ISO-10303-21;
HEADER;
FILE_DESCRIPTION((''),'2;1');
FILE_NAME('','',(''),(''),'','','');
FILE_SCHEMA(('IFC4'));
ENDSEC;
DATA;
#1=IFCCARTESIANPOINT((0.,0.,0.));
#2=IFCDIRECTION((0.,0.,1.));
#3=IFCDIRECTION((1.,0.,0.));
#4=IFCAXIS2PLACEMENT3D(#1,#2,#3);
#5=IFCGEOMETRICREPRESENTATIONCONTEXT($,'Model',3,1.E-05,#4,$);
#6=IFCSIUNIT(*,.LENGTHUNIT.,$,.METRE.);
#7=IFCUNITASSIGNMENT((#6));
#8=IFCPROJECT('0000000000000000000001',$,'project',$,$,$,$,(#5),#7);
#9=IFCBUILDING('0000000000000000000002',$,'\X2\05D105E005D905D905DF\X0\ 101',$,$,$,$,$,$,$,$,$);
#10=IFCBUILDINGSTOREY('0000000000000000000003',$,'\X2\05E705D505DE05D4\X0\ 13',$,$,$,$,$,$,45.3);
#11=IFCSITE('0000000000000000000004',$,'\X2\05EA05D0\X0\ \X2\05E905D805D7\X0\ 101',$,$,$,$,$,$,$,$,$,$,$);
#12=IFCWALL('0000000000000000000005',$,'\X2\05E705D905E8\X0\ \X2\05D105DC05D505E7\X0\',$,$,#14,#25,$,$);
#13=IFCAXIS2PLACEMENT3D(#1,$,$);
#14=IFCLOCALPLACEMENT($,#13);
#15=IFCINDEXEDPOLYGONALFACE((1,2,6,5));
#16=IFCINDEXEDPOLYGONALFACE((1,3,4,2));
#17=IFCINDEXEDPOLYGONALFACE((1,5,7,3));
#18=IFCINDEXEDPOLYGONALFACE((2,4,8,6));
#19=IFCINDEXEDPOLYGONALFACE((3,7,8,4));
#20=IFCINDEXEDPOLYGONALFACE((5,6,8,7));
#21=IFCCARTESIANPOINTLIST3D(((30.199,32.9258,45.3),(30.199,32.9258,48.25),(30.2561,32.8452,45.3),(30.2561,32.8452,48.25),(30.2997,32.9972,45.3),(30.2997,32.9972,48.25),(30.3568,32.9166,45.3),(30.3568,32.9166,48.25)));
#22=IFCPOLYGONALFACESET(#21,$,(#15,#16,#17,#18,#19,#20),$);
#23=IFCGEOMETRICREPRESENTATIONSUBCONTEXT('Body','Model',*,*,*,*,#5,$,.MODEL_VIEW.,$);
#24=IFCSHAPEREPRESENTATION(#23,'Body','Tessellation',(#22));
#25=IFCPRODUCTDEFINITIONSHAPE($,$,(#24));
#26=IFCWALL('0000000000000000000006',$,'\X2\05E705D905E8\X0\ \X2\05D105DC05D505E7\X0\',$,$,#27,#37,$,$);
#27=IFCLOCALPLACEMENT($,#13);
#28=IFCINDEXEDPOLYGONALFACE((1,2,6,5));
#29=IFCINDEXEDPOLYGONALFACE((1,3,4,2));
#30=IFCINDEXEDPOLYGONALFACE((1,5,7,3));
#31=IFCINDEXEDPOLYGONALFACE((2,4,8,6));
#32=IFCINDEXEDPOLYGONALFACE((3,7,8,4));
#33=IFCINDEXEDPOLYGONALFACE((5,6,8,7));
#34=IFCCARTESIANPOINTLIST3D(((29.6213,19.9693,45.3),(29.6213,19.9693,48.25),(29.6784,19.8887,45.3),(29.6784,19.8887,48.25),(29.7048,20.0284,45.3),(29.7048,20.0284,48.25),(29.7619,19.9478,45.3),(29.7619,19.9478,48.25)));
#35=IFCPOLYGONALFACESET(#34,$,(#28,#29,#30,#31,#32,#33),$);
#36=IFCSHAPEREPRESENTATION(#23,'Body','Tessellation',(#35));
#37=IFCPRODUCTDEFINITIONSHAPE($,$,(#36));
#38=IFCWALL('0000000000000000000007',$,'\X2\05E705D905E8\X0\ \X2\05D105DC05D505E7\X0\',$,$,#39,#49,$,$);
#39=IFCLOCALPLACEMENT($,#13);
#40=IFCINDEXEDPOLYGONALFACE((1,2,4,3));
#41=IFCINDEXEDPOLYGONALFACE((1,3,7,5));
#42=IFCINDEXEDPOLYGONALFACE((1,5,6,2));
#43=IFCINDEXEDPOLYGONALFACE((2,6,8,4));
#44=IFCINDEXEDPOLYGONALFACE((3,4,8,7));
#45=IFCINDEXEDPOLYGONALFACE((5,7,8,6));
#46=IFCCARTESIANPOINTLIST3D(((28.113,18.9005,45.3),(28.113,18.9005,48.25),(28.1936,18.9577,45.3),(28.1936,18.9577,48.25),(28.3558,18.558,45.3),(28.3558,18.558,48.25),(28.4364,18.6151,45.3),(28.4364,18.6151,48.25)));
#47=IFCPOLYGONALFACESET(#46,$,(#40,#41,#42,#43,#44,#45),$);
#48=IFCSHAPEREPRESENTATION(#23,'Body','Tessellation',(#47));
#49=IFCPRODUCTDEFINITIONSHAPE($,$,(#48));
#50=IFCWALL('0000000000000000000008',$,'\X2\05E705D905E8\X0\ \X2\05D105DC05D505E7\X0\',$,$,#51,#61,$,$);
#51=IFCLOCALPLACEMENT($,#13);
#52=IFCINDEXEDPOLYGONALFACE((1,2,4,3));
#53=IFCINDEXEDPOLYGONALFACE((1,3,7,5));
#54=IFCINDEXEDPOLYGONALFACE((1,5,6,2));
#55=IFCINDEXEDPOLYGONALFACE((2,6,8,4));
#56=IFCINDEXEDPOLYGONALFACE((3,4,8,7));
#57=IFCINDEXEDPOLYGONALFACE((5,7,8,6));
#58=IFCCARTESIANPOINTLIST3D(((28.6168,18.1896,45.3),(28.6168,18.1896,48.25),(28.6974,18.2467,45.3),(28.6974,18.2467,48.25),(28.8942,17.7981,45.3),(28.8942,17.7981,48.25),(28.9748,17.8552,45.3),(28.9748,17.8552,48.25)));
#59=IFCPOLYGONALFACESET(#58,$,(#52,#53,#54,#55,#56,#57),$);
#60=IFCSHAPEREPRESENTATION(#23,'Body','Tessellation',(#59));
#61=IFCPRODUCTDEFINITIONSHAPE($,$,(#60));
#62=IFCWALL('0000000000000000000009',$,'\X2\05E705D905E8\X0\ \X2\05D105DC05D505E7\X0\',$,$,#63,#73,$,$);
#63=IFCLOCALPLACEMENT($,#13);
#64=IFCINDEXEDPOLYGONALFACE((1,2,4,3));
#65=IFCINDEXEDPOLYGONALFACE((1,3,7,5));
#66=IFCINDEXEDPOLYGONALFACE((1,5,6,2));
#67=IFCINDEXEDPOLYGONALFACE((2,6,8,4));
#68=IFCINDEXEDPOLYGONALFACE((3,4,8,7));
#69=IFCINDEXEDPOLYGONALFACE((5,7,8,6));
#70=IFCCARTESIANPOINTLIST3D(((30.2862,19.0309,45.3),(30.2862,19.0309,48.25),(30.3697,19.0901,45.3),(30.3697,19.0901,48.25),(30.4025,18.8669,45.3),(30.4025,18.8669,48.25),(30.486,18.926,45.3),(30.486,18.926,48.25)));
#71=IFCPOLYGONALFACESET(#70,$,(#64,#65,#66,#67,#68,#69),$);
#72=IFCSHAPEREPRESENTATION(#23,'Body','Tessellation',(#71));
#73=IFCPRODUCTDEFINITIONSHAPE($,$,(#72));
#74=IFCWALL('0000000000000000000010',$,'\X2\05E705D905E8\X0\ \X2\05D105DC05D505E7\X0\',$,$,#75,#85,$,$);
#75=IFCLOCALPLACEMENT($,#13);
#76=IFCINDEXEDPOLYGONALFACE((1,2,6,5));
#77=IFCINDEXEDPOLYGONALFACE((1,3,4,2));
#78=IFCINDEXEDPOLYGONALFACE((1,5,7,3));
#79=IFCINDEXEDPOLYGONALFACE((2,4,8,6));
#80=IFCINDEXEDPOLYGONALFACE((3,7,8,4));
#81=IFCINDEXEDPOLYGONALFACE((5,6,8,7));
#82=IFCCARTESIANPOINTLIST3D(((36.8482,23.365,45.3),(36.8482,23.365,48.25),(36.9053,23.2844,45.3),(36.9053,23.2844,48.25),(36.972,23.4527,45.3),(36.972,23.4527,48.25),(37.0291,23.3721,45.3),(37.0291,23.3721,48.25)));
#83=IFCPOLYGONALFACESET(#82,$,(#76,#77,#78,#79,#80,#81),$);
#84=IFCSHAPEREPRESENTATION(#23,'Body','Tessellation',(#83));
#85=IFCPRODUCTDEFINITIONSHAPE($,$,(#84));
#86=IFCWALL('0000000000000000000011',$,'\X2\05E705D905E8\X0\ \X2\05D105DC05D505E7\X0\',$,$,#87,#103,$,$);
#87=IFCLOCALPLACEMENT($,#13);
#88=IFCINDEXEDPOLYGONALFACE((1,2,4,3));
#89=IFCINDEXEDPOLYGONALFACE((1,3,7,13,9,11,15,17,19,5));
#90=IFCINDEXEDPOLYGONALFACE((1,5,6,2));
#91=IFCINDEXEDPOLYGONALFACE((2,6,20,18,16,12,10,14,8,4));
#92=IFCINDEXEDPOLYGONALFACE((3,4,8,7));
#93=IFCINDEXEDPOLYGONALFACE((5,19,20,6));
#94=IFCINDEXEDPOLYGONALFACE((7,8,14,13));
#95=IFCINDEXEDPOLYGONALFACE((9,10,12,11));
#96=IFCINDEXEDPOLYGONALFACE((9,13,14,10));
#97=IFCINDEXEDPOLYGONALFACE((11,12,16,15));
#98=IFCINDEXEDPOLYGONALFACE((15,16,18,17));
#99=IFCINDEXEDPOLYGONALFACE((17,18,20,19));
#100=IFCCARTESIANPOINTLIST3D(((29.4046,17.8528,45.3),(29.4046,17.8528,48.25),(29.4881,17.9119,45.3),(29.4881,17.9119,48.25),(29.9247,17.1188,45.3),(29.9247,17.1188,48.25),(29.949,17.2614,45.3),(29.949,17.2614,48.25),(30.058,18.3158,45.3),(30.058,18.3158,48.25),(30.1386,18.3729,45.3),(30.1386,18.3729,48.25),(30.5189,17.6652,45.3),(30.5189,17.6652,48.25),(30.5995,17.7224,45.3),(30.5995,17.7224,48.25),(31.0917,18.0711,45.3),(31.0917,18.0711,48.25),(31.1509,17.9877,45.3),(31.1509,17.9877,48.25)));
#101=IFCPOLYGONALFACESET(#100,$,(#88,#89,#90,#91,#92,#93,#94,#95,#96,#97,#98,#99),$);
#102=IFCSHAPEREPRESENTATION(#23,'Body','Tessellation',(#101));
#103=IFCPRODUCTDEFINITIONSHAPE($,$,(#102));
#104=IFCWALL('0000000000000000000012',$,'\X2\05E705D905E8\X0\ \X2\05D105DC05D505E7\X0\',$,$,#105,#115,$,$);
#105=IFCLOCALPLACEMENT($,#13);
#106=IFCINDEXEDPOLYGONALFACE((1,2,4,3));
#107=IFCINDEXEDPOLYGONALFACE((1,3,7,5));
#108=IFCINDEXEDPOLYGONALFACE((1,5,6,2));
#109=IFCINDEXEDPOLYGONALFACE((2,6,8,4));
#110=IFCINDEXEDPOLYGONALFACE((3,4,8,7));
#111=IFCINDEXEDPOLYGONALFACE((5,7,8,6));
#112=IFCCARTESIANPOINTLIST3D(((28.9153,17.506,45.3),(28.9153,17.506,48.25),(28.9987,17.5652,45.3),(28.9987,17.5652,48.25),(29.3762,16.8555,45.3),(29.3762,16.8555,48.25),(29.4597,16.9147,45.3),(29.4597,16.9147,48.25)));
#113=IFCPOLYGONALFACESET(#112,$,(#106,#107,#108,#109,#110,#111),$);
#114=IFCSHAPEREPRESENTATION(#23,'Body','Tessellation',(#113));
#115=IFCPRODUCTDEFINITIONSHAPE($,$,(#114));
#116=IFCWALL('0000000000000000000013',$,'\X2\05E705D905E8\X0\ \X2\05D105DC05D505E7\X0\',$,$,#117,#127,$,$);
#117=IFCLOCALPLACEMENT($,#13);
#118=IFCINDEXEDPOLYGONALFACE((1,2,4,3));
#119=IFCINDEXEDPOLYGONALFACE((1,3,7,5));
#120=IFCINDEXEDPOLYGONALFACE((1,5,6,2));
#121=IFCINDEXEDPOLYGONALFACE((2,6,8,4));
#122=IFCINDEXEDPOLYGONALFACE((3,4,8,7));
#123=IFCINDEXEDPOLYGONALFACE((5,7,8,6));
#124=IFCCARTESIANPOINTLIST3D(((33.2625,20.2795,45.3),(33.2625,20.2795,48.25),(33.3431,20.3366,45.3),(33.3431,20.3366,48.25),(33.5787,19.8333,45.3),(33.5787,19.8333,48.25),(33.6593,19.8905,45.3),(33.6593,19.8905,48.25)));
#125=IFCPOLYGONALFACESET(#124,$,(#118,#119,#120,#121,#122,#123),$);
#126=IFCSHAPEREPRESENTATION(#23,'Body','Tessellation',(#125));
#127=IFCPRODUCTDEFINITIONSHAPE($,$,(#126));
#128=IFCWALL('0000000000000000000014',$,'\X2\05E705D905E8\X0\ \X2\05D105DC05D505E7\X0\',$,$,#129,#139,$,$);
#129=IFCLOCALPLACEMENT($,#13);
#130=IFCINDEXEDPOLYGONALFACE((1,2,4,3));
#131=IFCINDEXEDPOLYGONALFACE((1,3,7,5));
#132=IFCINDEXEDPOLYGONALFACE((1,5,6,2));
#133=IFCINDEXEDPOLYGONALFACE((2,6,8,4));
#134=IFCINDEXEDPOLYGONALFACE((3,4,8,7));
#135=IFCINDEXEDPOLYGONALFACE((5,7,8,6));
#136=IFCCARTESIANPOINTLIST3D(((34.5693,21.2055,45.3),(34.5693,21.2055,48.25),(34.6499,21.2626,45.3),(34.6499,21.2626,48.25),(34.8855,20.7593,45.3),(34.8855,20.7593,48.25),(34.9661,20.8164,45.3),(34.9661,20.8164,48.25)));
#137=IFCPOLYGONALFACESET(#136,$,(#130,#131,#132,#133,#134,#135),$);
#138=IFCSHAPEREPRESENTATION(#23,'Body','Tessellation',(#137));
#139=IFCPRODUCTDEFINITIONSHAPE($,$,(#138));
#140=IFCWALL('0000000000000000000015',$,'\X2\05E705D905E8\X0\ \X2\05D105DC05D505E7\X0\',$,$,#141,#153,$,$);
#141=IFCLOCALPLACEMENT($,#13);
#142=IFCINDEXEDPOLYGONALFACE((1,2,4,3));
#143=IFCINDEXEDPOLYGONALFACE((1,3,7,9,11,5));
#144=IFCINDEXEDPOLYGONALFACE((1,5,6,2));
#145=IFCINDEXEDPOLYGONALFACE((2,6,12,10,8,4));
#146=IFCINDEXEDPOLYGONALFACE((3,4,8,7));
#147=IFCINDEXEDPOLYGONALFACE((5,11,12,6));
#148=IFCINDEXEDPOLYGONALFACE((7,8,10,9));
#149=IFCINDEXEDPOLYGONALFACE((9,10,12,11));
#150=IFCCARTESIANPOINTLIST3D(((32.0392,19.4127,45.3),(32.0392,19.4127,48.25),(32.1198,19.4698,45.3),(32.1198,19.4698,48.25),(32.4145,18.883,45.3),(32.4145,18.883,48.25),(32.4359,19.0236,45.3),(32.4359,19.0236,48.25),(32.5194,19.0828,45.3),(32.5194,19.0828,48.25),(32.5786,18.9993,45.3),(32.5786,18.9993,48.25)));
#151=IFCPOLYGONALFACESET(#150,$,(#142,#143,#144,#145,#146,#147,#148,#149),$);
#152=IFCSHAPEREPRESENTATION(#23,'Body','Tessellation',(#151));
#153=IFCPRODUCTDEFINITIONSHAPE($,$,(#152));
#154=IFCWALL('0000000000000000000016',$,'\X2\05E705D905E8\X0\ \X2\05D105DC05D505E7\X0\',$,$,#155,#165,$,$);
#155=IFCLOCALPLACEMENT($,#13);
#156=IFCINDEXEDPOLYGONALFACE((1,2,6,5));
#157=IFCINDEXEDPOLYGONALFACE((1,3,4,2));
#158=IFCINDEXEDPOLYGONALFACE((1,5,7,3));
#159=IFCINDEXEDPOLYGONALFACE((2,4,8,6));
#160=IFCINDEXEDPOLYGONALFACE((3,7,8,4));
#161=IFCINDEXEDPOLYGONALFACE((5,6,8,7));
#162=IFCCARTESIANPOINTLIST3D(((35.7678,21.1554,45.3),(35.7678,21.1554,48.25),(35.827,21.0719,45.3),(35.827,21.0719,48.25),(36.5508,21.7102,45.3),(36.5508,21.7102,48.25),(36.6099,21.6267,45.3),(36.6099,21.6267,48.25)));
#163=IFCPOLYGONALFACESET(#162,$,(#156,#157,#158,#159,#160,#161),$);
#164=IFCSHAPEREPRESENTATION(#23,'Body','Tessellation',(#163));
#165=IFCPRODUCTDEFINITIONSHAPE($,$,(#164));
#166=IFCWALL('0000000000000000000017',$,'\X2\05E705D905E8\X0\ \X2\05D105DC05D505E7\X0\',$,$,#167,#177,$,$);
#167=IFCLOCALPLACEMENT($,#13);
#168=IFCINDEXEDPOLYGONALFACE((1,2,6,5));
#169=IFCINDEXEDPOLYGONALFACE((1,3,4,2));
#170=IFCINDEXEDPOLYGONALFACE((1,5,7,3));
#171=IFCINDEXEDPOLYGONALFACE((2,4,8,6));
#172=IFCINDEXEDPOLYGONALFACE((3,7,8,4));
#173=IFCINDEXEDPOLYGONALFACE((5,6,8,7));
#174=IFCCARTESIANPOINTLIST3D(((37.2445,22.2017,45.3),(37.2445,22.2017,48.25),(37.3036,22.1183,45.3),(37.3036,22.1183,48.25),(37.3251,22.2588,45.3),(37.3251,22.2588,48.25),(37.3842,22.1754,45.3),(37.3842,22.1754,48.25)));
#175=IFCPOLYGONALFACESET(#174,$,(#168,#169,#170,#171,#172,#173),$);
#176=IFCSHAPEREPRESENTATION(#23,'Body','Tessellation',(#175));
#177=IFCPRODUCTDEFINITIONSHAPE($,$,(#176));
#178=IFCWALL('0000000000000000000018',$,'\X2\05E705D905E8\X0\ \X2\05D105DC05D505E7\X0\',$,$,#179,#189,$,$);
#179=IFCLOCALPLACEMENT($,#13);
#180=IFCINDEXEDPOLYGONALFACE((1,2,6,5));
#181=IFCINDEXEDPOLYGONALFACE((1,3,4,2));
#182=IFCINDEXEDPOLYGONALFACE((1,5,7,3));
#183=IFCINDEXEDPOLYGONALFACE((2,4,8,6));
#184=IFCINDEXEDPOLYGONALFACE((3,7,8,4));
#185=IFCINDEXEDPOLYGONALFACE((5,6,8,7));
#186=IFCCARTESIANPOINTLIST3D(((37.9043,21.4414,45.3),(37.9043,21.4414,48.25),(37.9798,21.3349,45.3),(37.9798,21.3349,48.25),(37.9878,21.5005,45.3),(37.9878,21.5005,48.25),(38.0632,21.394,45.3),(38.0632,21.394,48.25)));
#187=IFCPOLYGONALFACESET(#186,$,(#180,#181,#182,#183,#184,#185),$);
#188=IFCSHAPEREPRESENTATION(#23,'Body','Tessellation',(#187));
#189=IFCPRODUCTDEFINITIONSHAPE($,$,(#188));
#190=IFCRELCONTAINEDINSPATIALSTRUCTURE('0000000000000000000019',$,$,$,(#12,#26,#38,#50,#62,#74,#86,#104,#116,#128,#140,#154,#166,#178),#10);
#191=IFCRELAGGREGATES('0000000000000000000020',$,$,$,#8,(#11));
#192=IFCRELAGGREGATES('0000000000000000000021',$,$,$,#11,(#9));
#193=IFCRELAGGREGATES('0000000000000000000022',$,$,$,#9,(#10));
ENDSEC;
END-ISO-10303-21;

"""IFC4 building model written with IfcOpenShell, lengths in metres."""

from ifc_helpers import new_model, si_unit, frame, origin_with_axes, context, subcontext, project, spatial, polyline, outline, extrude, element, save


model = new_model("IFC4")

# Units and contexts
model_context = context("Model", 3, precision=1e-05, world=origin_with_axes())
body_context = subcontext(model_context, "Body", "Model", "MODEL_VIEW")
ifc_project = project(units=[si_unit("LENGTHUNIT", "METRE")], contexts=[model_context])

# Site, building, storey
site = spatial("IfcSite", under=ifc_project, Name="תא שטח 101")
building = spatial("IfcBuilding", under=site, Name="בניין 101")
storey = spatial("IfcBuildingStorey", under=building, Name="קומה 13", Elevation=45.3)

# Walls
element("IfcWall", 1, inside=storey, Name="קיר בלוק", context=body_context, shape_type="SweptSolid", body=[
    extrude(outline(polyline([(30.2997, 32.9972), (30.199, 32.9258), (30.2561, 32.8452), (30.3568, 32.9166), (30.2997, 32.9972)])), frame((0.0, 0.0, 45.3)), (0.0, 0.0, 1.0), 2.95),
])
element("IfcWall", 2, inside=storey, Name="קיר בלוק", context=body_context, shape_type="SweptSolid", body=[
    extrude(outline(polyline([(29.6784, 19.8887), (29.7619, 19.9478), (29.7048, 20.0284), (29.6213, 19.9693), (29.6784, 19.8887)])), frame((0.0, 0.0, 45.3)), (0.0, 0.0, 1.0), 2.95),
])
element("IfcWall", 3, inside=storey, Name="קיר בלוק", context=body_context, shape_type="SweptSolid", body=[
    extrude(outline(polyline([(28.113, 18.9005), (28.3558, 18.558), (28.4364, 18.6151), (28.1936, 18.9577), (28.113, 18.9005)])), frame((0.0, 0.0, 45.3)), (0.0, 0.0, 1.0), 2.95),
])
element("IfcWall", 4, inside=storey, Name="קיר בלוק", context=body_context, shape_type="SweptSolid", body=[
    extrude(outline(polyline([(28.6974, 18.2467), (28.6168, 18.1896), (28.8942, 17.7981), (28.9748, 17.8552), (28.6974, 18.2467)])), frame((0.0, 0.0, 45.3)), (0.0, 0.0, 1.0), 2.95),
])
element("IfcWall", 5, inside=storey, Name="קיר בלוק", context=body_context, shape_type="SweptSolid", body=[
    extrude(outline(polyline([(30.4025, 18.8669), (30.486, 18.926), (30.3697, 19.0901), (30.2862, 19.0309), (30.4025, 18.8669)])), frame((0.0, 0.0, 45.3)), (0.0, 0.0, 1.0), 2.95),
])
element("IfcWall", 6, inside=storey, Name="קיר בלוק", context=body_context, shape_type="SweptSolid", body=[
    extrude(outline(polyline([(36.8482, 23.365), (36.9053, 23.2844), (37.0291, 23.3721), (36.972, 23.4527), (36.8482, 23.365)])), frame((0.0, 0.0, 45.3)), (0.0, 0.0, 1.0), 2.95),
])
element("IfcWall", 7, inside=storey, Name="קיר בלוק", context=body_context, shape_type="SweptSolid", body=[
    extrude(outline(polyline([(30.5189, 17.6652), (29.949, 17.2614), (29.4881, 17.9119), (29.4046, 17.8528), (29.9247, 17.1188), (31.1509, 17.9877), (31.0917, 18.0711), (30.5995, 17.7224), (30.1386, 18.3729), (30.058, 18.3158), (30.5189, 17.6652)])), frame((0.0, 0.0, 45.3)), (0.0, 0.0, 1.0), 2.95),
])
element("IfcWall", 8, inside=storey, Name="קיר בלוק", context=body_context, shape_type="SweptSolid", body=[
    extrude(outline(polyline([(28.9987, 17.5652), (28.9153, 17.506), (29.3762, 16.8555), (29.4597, 16.9147), (28.9987, 17.5652)])), frame((0.0, 0.0, 45.3)), (0.0, 0.0, 1.0), 2.95),
])
element("IfcWall", 9, inside=storey, Name="קיר בלוק", context=body_context, shape_type="SweptSolid", body=[
    extrude(outline(polyline([(33.5787, 19.8333), (33.6593, 19.8905), (33.3431, 20.3366), (33.2625, 20.2795), (33.5787, 19.8333)])), frame((0.0, 0.0, 45.3)), (0.0, 0.0, 1.0), 2.95),
])
element("IfcWall", 10, inside=storey, Name="קיר בלוק", context=body_context, shape_type="SweptSolid", body=[
    extrude(outline(polyline([(34.9661, 20.8164), (34.6499, 21.2626), (34.5693, 21.2055), (34.8855, 20.7593), (34.9661, 20.8164)])), frame((0.0, 0.0, 45.3)), (0.0, 0.0, 1.0), 2.95),
])
element("IfcWall", 11, inside=storey, Name="קיר בלוק", context=body_context, shape_type="SweptSolid", body=[
    extrude(outline(polyline([(32.5194, 19.0828), (32.4359, 19.0236), (32.1198, 19.4698), (32.0392, 19.4127), (32.4145, 18.883), (32.5786, 18.9993), (32.5194, 19.0828)])), frame((0.0, 0.0, 45.3)), (0.0, 0.0, 1.0), 2.95),
])
element("IfcWall", 12, inside=storey, Name="קיר בלוק", context=body_context, shape_type="SweptSolid", body=[
    extrude(outline(polyline([(36.6099, 21.6267), (36.5508, 21.7102), (35.7678, 21.1554), (35.827, 21.0719), (36.6099, 21.6267)])), frame((0.0, 0.0, 45.3)), (0.0, 0.0, 1.0), 2.95),
])
element("IfcWall", 13, inside=storey, Name="קיר בלוק", context=body_context, shape_type="SweptSolid", body=[
    extrude(outline(polyline([(37.2445, 22.2017), (37.3036, 22.1183), (37.3842, 22.1754), (37.3251, 22.2588), (37.2445, 22.2017)])), frame((0.0, 0.0, 45.3)), (0.0, 0.0, 1.0), 2.95),
])
element("IfcWall", 14, inside=storey, Name="קיר בלוק", context=body_context, shape_type="SweptSolid", body=[
    extrude(outline(polyline([(37.9878, 21.5005), (37.9043, 21.4414), (37.9798, 21.3349), (38.0632, 21.394), (37.9878, 21.5005)])), frame((0.0, 0.0, 45.3)), (0.0, 0.0, 1.0), 2.95),
])

save(model, "model.ifc")
